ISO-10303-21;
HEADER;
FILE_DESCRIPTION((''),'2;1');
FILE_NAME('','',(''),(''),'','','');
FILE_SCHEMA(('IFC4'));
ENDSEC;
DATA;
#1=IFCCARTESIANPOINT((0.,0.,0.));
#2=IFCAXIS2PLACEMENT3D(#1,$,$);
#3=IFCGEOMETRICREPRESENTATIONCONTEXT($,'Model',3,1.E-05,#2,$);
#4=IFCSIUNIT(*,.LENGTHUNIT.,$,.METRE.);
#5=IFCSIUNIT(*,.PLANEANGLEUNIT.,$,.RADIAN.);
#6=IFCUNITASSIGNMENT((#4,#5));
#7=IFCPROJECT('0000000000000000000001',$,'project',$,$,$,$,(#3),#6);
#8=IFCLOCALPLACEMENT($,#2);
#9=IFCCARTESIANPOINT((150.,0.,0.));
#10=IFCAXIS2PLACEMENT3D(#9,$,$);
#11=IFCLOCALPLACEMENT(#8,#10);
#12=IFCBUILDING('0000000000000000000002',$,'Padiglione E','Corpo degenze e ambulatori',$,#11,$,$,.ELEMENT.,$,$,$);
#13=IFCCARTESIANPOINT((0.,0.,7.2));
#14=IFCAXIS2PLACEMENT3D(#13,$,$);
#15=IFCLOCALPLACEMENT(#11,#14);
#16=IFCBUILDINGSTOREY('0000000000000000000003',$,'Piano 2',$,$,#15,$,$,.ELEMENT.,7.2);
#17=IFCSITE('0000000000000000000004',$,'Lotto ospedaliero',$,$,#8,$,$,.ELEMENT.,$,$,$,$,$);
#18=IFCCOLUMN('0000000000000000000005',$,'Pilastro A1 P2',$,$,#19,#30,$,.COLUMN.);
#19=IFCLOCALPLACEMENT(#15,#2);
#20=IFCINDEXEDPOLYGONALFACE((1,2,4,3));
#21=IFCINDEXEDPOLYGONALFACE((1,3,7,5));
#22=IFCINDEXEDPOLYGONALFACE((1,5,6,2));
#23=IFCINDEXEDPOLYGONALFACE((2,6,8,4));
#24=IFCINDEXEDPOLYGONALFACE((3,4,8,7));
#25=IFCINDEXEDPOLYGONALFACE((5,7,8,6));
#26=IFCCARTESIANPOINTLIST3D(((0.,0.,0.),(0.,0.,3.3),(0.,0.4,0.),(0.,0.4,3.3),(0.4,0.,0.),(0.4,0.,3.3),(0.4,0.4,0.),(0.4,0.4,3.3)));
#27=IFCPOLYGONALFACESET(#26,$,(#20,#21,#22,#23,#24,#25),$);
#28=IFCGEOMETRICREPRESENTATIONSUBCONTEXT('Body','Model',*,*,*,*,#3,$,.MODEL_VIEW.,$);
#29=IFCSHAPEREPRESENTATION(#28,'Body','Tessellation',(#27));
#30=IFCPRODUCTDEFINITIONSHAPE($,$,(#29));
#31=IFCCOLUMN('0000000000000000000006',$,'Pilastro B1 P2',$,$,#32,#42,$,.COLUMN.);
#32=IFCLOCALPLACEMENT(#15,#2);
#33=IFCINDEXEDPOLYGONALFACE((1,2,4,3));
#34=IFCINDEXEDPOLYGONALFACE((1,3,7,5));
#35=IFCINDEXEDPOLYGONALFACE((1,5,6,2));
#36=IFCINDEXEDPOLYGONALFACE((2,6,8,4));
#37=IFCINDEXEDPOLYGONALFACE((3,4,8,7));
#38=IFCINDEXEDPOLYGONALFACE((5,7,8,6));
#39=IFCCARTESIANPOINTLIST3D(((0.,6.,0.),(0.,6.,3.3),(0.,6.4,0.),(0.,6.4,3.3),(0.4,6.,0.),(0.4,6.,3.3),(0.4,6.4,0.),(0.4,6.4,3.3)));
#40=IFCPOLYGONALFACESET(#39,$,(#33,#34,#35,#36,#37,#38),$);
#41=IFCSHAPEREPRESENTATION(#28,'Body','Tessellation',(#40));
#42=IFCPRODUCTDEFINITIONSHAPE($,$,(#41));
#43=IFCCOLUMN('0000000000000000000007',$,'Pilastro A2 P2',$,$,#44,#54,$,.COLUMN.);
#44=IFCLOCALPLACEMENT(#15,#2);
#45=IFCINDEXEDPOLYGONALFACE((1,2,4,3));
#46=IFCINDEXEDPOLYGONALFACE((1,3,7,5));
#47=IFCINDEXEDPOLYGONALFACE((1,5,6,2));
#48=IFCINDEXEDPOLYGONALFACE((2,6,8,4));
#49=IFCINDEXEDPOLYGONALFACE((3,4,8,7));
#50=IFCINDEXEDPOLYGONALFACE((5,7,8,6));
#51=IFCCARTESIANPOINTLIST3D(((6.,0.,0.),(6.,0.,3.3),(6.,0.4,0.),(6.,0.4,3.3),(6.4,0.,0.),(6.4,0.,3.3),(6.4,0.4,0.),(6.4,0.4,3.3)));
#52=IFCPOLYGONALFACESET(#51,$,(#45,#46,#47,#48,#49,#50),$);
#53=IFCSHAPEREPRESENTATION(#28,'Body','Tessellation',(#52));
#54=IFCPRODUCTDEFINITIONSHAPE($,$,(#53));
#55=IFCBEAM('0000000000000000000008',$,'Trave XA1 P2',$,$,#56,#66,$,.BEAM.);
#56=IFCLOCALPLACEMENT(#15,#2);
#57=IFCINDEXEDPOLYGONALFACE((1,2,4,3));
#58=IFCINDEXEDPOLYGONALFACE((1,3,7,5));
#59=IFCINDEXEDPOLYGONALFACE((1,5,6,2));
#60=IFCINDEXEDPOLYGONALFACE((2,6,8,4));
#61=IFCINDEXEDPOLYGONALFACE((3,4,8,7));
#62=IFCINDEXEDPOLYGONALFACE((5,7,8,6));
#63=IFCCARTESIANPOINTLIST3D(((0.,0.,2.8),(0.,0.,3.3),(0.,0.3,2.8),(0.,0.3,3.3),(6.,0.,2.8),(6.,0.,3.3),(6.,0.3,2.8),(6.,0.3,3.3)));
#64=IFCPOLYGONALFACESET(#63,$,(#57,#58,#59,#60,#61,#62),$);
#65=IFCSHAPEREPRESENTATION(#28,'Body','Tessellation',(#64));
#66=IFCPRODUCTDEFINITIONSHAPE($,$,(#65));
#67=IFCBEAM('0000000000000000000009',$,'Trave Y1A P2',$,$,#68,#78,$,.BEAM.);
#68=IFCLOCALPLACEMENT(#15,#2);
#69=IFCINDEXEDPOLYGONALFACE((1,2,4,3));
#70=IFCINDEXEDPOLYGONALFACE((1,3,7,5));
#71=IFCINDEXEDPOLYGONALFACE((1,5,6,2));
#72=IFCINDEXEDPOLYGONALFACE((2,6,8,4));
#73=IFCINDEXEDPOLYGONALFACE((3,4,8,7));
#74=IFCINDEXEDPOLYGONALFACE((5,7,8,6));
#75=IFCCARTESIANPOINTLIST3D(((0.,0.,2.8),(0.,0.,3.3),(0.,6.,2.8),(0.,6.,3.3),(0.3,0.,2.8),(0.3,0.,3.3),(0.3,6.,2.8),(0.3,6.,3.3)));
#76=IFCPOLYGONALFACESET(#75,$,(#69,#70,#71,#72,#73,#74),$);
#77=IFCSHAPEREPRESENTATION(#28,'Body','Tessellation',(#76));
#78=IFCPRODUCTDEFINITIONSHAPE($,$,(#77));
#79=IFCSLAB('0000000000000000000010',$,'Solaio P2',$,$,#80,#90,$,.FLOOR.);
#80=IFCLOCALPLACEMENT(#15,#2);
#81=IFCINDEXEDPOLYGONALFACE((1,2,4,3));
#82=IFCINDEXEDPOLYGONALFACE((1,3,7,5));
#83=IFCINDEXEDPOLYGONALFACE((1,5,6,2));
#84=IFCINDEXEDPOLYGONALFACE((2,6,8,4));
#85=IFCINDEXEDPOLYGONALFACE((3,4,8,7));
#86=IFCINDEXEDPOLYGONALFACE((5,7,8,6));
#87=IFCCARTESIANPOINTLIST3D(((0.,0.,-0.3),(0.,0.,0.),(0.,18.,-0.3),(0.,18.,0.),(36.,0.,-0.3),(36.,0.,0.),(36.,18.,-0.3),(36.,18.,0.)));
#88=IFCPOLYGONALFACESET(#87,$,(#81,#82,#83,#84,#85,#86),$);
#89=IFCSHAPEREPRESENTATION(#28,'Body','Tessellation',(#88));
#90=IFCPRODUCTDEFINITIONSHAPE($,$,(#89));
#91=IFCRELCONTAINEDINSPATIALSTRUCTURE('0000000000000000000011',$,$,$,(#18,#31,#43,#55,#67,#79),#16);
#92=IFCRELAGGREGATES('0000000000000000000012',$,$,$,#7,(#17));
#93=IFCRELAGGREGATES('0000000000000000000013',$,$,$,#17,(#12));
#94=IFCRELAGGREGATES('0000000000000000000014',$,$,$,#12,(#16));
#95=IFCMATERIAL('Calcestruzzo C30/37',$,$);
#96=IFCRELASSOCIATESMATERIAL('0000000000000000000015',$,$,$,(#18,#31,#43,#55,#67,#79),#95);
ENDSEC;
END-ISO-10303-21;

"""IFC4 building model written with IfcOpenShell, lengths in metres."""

from ifc_helpers import new_model, si_unit, frame, frame_2d, origin, place, context, subcontext, project, spatial, rectangle, extrude, material, element, save


model = new_model("IFC4")

# Units and contexts
model_context = context("Model", 3, precision=1e-05, world=origin())
body_context = subcontext(model_context, "Body", "Model", "MODEL_VIEW")
ifc_project = project(units=[si_unit("LENGTHUNIT", "METRE"), si_unit("PLANEANGLEUNIT", "RADIAN")], contexts=[model_context])

# Site, building, storey
site_placement = place(None, origin())
site = spatial("IfcSite", under=ifc_project, at=site_placement, Name="Lotto ospedaliero", CompositionType="ELEMENT")
building_placement = place(site_placement, frame((150.0, 0.0, 0.0)))
building = spatial("IfcBuilding", under=site, at=building_placement, Name="Padiglione E", Description="Corpo degenze e ambulatori", CompositionType="ELEMENT")
storey_placement = place(building_placement, frame((0.0, 0.0, 7.2)))
storey = spatial("IfcBuildingStorey", under=building, at=storey_placement, Name="Piano 2", CompositionType="ELEMENT", Elevation=7.2)

# Columns
ifc_material_1 = material(Name="Calcestruzzo C30/37")
for number, where, name in (
    (1, (0.0, 0.0, 0.0), "Pilastro A1 P2"),
    (2, (0.0, 6.0, 0.0), "Pilastro B1 P2"),
    (3, (6.0, 0.0, 0.0), "Pilastro A2 P2"),
):
    element("IfcColumn", number, at=place(storey_placement, frame(where)), inside=storey, material=ifc_material_1, Name=name, PredefinedType="COLUMN", context=body_context, shape_type="SweptSolid", body=[
        extrude(rectangle(XDim=0.4, YDim=0.4, at=frame_2d((0.2, 0.2))), origin(), (0.0, 0.0, 1.0), 3.3),
    ])

# Beams
beam_1_placement = place(storey_placement, frame((0.0, 0.0, 2.8)))
element("IfcBeam", 4, at=beam_1_placement, inside=storey, material=ifc_material_1, Name="Trave XA1 P2", PredefinedType="BEAM", context=body_context, shape_type="SweptSolid", body=[
    extrude(rectangle(XDim=6.0, YDim=0.3, at=frame_2d((3.0, 0.15))), origin(), (0.0, 0.0, 1.0), 0.5),
])
beam_2_placement = place(storey_placement, frame((0.0, 0.0, 2.8)))
element("IfcBeam", 5, at=beam_2_placement, inside=storey, material=ifc_material_1, Name="Trave Y1A P2", PredefinedType="BEAM", context=body_context, shape_type="SweptSolid", body=[
    extrude(rectangle(XDim=0.3, YDim=6.0, at=frame_2d((0.15, 3.0))), origin(), (0.0, 0.0, 1.0), 0.5),
])

# Slab
slab_placement = place(storey_placement, frame((0.0, 0.0, -0.3)))
element("IfcSlab", 6, at=slab_placement, inside=storey, material=ifc_material_1, Name="Solaio P2", PredefinedType="FLOOR", context=body_context, shape_type="SweptSolid", body=[
    extrude(rectangle(XDim=36.0, YDim=18.0, at=frame_2d((18.0, 9.0))), origin(), (0.0, 0.0, 1.0), 0.3),
])

save(model, "model.ifc")
